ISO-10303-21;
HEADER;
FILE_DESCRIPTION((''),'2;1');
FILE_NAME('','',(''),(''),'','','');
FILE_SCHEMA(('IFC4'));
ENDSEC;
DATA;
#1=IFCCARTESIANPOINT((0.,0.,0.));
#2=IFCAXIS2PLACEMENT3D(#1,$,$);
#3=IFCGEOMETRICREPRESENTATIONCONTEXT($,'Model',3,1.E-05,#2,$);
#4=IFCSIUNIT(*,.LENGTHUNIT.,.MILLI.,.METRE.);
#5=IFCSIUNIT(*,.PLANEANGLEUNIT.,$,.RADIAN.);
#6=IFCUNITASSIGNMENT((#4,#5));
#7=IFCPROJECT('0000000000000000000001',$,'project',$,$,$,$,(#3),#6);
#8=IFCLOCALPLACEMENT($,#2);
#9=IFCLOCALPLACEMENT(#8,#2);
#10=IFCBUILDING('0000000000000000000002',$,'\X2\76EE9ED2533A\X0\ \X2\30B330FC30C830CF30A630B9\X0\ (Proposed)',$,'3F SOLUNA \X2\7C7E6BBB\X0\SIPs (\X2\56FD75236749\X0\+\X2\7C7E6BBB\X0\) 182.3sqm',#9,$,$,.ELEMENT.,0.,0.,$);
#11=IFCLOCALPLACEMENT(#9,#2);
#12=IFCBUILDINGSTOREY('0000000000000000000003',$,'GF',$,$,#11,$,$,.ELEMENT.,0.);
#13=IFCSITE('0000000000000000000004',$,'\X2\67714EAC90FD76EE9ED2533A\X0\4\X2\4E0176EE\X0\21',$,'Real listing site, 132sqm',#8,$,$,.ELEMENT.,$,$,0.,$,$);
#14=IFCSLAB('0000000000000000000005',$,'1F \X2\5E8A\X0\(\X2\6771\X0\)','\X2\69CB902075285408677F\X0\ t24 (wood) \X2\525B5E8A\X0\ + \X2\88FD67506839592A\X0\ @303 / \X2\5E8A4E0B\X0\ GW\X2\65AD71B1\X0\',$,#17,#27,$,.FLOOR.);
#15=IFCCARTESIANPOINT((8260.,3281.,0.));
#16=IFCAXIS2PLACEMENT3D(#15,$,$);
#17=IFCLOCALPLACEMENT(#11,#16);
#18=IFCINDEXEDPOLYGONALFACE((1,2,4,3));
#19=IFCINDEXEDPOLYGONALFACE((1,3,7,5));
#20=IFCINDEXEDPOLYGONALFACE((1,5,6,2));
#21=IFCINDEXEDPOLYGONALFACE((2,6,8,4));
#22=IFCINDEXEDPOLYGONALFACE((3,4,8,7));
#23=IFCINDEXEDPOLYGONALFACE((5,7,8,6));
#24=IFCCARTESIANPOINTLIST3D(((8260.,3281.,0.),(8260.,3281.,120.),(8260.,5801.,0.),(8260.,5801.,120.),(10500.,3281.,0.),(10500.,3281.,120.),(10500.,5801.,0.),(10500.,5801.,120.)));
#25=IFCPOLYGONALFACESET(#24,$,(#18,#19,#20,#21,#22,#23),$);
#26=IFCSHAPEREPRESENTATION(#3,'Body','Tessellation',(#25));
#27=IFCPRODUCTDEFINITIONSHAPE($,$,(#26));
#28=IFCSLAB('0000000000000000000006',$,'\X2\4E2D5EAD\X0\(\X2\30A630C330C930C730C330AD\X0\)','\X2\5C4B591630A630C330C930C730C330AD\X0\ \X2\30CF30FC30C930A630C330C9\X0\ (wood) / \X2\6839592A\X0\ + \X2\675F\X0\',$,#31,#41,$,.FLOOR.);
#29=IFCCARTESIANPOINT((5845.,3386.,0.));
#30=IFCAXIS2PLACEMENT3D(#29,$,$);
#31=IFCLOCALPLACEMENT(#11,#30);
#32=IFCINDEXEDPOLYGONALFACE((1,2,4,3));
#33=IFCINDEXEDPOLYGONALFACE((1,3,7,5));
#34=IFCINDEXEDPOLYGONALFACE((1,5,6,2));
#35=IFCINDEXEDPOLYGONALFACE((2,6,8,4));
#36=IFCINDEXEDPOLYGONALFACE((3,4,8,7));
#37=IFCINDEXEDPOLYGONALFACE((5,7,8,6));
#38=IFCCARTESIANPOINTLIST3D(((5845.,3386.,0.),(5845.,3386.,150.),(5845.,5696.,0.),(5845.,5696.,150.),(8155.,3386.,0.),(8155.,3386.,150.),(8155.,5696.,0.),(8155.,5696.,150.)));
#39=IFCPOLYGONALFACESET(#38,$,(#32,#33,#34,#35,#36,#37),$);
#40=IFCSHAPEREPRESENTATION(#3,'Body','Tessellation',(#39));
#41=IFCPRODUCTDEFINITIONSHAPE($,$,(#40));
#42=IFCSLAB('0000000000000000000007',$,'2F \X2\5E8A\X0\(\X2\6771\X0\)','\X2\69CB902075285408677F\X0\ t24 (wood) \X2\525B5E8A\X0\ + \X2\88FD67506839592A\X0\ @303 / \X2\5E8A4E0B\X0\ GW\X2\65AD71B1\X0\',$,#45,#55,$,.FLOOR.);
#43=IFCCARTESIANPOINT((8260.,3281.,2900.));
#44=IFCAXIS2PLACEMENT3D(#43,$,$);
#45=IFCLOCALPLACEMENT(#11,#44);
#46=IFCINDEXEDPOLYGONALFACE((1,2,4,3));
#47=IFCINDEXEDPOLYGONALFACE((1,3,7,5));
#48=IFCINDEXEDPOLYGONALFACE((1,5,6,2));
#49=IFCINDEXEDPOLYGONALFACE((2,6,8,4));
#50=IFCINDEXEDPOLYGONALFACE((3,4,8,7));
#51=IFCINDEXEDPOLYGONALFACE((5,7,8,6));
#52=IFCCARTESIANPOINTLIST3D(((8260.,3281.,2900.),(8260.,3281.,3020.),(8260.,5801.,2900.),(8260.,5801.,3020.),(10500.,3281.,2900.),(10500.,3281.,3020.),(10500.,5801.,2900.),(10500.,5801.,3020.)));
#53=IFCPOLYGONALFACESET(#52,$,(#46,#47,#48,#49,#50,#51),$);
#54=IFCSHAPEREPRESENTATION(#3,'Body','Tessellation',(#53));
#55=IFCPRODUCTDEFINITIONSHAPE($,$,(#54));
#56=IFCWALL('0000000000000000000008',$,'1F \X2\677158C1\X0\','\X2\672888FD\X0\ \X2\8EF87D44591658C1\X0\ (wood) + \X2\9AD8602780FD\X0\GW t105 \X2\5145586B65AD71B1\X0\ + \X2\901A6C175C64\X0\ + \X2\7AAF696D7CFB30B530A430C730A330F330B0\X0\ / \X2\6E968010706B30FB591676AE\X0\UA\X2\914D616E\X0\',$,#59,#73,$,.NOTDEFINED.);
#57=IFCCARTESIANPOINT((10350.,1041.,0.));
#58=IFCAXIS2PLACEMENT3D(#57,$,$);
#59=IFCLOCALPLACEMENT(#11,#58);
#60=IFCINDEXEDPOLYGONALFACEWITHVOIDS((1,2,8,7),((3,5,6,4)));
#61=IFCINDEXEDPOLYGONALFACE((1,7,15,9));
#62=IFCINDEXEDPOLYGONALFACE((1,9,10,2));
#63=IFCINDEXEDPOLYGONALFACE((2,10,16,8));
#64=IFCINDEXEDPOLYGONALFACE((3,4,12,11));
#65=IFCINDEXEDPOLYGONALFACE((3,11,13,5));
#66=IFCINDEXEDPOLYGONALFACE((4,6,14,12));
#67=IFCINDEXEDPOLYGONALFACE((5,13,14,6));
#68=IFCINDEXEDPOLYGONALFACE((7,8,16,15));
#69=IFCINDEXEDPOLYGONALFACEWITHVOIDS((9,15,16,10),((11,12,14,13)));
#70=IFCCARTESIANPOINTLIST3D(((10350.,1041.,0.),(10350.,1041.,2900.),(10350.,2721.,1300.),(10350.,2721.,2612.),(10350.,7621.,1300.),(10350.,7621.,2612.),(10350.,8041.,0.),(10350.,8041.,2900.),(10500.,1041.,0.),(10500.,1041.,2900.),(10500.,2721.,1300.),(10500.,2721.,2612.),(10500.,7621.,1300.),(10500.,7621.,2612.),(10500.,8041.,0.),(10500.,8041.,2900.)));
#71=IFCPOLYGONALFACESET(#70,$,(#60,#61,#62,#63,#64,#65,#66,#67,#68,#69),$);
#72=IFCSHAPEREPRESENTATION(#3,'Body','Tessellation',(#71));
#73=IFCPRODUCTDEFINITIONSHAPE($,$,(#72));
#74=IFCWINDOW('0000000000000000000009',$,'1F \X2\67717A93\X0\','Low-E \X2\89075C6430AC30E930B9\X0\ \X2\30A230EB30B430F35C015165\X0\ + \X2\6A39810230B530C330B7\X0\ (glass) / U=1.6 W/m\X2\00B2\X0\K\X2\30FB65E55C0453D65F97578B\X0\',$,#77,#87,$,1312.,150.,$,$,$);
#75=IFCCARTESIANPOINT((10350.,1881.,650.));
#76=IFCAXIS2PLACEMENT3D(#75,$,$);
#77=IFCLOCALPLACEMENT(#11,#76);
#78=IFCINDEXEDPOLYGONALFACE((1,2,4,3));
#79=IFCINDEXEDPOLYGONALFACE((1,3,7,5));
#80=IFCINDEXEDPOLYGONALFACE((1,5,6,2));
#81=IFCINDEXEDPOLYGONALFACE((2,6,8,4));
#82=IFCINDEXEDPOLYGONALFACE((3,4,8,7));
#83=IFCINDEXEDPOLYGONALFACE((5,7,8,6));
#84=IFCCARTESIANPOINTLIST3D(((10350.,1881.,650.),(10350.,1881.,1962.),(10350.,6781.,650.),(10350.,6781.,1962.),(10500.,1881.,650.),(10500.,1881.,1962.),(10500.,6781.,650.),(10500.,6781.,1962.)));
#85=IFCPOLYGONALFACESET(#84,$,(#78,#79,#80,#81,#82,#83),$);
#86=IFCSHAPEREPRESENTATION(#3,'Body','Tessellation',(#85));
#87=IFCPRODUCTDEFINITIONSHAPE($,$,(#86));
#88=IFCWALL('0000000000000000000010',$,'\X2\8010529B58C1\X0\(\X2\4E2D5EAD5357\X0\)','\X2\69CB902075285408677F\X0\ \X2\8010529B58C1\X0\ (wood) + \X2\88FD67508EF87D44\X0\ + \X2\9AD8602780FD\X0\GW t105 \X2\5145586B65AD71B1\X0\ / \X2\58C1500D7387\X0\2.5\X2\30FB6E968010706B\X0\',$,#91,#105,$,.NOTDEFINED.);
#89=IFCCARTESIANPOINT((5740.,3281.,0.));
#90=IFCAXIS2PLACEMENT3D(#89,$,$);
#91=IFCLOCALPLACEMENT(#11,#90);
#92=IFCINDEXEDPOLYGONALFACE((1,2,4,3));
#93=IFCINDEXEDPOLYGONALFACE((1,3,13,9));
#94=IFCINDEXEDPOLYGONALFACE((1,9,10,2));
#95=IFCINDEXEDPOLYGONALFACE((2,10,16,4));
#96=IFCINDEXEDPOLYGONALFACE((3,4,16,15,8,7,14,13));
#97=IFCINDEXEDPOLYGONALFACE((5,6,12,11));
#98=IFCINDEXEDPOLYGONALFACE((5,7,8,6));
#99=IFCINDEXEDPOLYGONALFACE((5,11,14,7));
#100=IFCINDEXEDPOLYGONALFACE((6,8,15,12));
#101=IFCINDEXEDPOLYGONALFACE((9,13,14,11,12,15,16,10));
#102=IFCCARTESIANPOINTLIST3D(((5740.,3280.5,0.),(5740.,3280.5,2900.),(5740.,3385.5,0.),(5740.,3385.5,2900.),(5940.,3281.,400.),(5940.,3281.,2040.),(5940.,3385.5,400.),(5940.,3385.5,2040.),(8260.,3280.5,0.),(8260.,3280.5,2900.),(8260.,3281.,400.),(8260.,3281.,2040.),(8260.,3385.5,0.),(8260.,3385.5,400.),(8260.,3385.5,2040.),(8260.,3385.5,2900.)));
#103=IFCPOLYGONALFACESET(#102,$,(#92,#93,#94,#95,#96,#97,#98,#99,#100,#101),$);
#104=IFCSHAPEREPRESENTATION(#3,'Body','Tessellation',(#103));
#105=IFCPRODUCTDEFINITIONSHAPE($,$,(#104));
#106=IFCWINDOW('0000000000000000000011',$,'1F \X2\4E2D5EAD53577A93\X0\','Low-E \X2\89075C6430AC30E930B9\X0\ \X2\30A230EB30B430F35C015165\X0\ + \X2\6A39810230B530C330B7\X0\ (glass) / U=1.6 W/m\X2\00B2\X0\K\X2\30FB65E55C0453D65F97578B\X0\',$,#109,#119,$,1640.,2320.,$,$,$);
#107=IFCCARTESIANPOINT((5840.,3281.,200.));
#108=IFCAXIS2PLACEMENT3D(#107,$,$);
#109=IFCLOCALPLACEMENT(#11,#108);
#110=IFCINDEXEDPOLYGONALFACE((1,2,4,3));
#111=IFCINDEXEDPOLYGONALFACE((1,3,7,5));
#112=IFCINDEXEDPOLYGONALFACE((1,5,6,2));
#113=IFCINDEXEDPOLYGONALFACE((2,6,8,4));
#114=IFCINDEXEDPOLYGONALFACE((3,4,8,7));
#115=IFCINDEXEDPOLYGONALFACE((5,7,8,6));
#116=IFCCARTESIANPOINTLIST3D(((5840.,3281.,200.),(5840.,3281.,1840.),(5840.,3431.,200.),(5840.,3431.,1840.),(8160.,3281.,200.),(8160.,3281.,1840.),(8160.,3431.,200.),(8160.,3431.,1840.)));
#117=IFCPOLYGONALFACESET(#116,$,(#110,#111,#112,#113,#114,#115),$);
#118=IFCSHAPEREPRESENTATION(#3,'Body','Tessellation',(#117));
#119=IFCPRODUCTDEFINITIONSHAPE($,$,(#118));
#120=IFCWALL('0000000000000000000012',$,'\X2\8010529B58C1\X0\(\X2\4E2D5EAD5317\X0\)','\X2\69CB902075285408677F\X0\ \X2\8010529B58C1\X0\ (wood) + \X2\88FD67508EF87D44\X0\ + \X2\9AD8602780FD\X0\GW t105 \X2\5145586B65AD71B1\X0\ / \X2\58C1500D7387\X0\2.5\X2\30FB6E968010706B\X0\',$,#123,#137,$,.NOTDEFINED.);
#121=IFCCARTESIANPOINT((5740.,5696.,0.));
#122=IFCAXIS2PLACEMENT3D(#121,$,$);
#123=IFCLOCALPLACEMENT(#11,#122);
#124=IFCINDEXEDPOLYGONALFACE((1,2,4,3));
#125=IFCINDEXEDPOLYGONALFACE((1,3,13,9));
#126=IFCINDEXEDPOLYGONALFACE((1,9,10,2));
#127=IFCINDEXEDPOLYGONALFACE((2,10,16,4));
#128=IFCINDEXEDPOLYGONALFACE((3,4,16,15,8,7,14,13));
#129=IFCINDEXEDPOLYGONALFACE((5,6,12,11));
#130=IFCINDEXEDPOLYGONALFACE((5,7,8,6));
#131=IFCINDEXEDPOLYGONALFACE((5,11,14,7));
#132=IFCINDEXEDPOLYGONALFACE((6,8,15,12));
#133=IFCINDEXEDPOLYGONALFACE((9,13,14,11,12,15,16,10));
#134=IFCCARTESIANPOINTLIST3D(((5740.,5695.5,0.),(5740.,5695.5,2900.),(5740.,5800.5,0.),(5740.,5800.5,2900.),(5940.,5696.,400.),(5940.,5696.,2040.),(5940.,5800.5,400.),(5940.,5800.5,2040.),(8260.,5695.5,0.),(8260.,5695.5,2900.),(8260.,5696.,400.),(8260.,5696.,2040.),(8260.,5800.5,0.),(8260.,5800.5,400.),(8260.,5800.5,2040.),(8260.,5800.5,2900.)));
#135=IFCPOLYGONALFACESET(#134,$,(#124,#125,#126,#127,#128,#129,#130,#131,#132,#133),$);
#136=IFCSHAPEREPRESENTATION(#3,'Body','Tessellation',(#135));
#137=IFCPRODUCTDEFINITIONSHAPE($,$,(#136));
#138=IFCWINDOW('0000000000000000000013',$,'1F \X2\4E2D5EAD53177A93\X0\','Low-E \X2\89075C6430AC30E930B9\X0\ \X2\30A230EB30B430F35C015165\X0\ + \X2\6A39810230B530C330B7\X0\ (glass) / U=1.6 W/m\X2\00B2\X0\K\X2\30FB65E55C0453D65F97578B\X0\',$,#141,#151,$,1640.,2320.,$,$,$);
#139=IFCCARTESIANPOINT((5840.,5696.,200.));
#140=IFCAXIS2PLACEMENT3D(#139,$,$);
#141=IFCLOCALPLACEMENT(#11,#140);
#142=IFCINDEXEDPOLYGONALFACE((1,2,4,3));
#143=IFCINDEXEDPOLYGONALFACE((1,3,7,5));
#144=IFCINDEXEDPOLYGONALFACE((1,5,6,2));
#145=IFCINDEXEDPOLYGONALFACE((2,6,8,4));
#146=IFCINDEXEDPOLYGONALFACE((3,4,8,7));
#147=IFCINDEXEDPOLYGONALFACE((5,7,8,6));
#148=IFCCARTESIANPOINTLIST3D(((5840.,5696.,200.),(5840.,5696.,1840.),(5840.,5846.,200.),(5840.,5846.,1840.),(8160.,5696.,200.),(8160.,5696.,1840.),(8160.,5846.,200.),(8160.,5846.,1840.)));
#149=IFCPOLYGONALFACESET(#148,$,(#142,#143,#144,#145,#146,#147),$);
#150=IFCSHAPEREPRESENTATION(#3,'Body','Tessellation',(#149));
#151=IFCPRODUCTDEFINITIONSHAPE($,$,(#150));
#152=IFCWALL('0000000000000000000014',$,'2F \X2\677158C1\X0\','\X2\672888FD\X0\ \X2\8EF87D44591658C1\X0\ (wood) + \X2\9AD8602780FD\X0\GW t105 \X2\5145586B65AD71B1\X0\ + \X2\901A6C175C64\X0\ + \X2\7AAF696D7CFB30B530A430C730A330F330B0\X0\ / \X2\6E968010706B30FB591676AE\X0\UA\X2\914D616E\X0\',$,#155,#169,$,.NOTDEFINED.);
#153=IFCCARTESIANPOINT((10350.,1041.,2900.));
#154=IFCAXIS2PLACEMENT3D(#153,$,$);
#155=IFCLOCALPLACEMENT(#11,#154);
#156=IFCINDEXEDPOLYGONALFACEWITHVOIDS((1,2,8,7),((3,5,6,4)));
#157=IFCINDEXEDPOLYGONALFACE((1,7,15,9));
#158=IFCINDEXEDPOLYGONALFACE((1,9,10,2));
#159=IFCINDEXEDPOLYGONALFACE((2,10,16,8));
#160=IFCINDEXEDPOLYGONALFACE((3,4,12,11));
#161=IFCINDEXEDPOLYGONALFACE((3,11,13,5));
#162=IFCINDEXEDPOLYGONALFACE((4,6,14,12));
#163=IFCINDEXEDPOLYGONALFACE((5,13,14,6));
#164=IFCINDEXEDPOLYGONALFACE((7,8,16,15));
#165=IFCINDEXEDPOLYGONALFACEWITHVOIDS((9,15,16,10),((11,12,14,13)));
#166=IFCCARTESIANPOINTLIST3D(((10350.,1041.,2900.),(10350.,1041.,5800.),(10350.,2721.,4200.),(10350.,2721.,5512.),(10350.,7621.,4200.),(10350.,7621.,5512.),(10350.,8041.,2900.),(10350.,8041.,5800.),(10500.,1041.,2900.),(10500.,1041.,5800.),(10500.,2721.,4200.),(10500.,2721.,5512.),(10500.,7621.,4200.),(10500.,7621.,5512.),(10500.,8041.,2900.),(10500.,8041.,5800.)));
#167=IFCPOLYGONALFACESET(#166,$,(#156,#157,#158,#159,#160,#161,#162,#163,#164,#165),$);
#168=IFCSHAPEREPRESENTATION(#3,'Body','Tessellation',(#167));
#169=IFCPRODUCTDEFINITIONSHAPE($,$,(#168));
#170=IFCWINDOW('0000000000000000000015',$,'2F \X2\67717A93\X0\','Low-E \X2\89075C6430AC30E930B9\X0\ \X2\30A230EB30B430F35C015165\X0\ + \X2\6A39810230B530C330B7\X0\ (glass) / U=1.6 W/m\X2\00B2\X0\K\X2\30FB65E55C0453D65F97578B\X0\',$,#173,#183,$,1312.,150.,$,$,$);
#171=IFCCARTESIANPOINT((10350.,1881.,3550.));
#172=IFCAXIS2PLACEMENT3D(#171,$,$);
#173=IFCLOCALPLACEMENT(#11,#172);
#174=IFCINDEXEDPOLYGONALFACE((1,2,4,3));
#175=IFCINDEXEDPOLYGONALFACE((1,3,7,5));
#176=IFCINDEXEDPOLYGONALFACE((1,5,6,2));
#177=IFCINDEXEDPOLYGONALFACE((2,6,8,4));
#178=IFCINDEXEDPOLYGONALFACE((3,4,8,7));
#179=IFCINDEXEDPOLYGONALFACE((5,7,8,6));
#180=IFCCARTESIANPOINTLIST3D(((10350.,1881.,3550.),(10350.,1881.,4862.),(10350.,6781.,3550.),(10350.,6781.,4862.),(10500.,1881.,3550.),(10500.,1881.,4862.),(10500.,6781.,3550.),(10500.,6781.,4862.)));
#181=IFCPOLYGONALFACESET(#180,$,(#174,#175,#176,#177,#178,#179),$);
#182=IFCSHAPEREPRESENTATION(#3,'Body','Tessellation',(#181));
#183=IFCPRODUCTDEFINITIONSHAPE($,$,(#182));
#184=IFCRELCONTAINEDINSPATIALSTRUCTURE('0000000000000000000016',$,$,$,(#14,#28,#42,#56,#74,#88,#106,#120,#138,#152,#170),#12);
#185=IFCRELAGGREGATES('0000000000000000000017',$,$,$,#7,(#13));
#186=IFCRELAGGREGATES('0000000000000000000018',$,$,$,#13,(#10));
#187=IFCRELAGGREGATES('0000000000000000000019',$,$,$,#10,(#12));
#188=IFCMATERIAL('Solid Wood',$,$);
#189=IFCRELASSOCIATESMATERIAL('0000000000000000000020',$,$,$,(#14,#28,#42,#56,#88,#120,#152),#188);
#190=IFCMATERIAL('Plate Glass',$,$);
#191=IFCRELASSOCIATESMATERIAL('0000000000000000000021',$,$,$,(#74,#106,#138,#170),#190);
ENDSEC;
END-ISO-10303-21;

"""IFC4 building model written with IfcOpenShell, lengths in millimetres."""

from ifc_helpers import new_model, si_unit, frame, frame_2d, origin, place, context, project, spatial, rectangle, extrude, material, element, fill, save


model = new_model("IFC4")

# Units and contexts
model_context = context("Model", 3, precision=1e-05, world=origin())
ifc_project = project(units=[si_unit("LENGTHUNIT", "METRE", prefix="MILLI"), si_unit("PLANEANGLEUNIT", "RADIAN")], contexts=[model_context])

# Site, building, storey
site_placement = place(None, origin())
site = spatial("IfcSite", under=ifc_project, at=site_placement, Name="東京都目黒区4丁目21", ObjectType="Real listing site, 132sqm", CompositionType="ELEMENT", RefElevation=0.0)
building_placement = place(site_placement, origin())
building = spatial("IfcBuilding", under=site, at=building_placement, Name="目黒区 コートハウス (Proposed)", ObjectType="3F SOLUNA 籾殻SIPs (国産杉+籾殻) 182.3sqm", CompositionType="ELEMENT", ElevationOfRefHeight=0.0, ElevationOfTerrain=0.0)
storey_placement = place(building_placement, origin())
storey = spatial("IfcBuildingStorey", under=building, at=storey_placement, Name="GF", CompositionType="ELEMENT", Elevation=0.0)

# Slabs
ifc_material_1 = material(Name="Solid Wood")
slab_1_placement = place(storey_placement, frame((8260.0, 3281.0, 0.0)))
element("IfcSlab", 1, at=slab_1_placement, inside=storey, material=ifc_material_1, Name="1F 床(東)", Description="構造用合板 t24 (wood) 剛床 + 製材根太 @303 / 床下 GW断熱", PredefinedType="FLOOR", context=model_context, shape_type="SweptSolid", body=[
    extrude(rectangle(XDim=2240.0, YDim=2520.0, at=frame_2d((1120.0, 1260.0))), frame((8260.0, 3281.0, 0.0)), (0.0, 0.0, 1.0), 120.0),
])
slab_2_placement = place(storey_placement, frame((5845.0, 3386.0, 0.0)))
element("IfcSlab", 2, at=slab_2_placement, inside=storey, material=ifc_material_1, Name="中庭(ウッドデッキ)", Description="屋外ウッドデッキ ハードウッド (wood) / 根太 + 束", PredefinedType="FLOOR", context=model_context, shape_type="SweptSolid", body=[
    extrude(rectangle(XDim=2310.0, YDim=2310.0, at=frame_2d((1155.0, 1155.0))), frame((5845.0, 3386.0, 0.0)), (0.0, 0.0, 1.0), 150.0),
])
slab_3_placement = place(storey_placement, frame((8260.0, 3281.0, 2900.0)))
element("IfcSlab", 3, at=slab_3_placement, inside=storey, material=ifc_material_1, Name="2F 床(東)", Description="構造用合板 t24 (wood) 剛床 + 製材根太 @303 / 床下 GW断熱", PredefinedType="FLOOR", context=model_context, shape_type="SweptSolid", body=[
    extrude(rectangle(XDim=2240.0, YDim=2520.0, at=frame_2d((1120.0, 1260.0))), frame((8260.0, 3281.0, 2900.0)), (0.0, 0.0, 1.0), 120.0),
])

# Walls, openings, windows
wall_1_placement = place(storey_placement, frame((10350.0, 1041.0, 0.0)))
wall_1 = element("IfcWall", 4, at=wall_1_placement, inside=storey, material=ifc_material_1, Name="1F 東壁", Description="木製 軸組外壁 (wood) + 高性能GW t105 充填断熱 + 通気層 + 窯業系サイディング / 準耐火・外皮UA配慮", PredefinedType="NOTDEFINED", context=model_context, shape_type="SweptSolid", body=[
    extrude(rectangle(XDim=150.0, YDim=7000.0, at=frame_2d((75.0, 3500.0))), frame((10350.0, 1041.0, 0.0)), (0.0, 0.0, 1.0), 2900.0),
])
opening_1_placement = place(storey_placement, frame((10350.0, 1881.0, 650.0)))
opening_1 = element("IfcOpeningElement", 5, at=opening_1_placement, cuts=wall_1, PredefinedType="NOTDEFINED", context=model_context, shape_type="SweptSolid", body=[
    extrude(rectangle(XDim=150.0, YDim=4900.0, at=frame_2d((75.0, 2450.0))), frame((10350.0, 1881.0, 650.0)), (0.0, 0.0, 1.0), 1312.0),
])
ifc_material_2 = material(Name="Plate Glass")
window_1_placement = place(storey_placement, frame((10350.0, 1881.0, 650.0)))
window_1 = element("IfcWindow", 6, at=window_1_placement, inside=storey, material=ifc_material_2, Name="1F 東窓", Description="Low-E 複層ガラス アルゴン封入 + 樹脂サッシ (glass) / U=1.6 W/m²K・日射取得型", OverallHeight=1312.0, OverallWidth=150.0, context=model_context, shape_type="SweptSolid", body=[
    extrude(rectangle(XDim=150.0, YDim=4900.0, at=frame_2d((75.0, 2450.0))), frame((10350.0, 1881.0, 650.0)), (0.0, 0.0, 1.0), 1312.0),
])
fill(opening_1, window_1)
wall_2_placement = place(storey_placement, frame((5740.0, 3281.0, 0.0)))
wall_2 = element("IfcWall", 7, at=wall_2_placement, inside=storey, material=ifc_material_1, Name="耐力壁(中庭南)", Description="構造用合板 耐力壁 (wood) + 製材軸組 + 高性能GW t105 充填断熱 / 壁倍率2.5・準耐火", PredefinedType="NOTDEFINED", context=model_context, shape_type="SweptSolid", body=[
    extrude(rectangle(XDim=2520.0, YDim=105.0, at=frame_2d((1260.0, 52.0))), frame((5740.0, 3281.0, 0.0)), (0.0, 0.0, 1.0), 2900.0),
])
opening_2_placement = place(storey_placement, frame((5840.0, 3281.0, 200.0)))
opening_2 = element("IfcOpeningElement", 8, at=opening_2_placement, cuts=wall_2, PredefinedType="NOTDEFINED", context=model_context, shape_type="SweptSolid", body=[
    extrude(rectangle(XDim=2320.0, YDim=150.0, at=frame_2d((1160.0, 75.0))), frame((5840.0, 3281.0, 200.0)), (0.0, 0.0, 1.0), 1640.0),
])
window_2_placement = place(storey_placement, frame((5840.0, 3281.0, 200.0)))
window_2 = element("IfcWindow", 9, at=window_2_placement, inside=storey, material=ifc_material_2, Name="1F 中庭南窓", Description="Low-E 複層ガラス アルゴン封入 + 樹脂サッシ (glass) / U=1.6 W/m²K・日射取得型", OverallHeight=1640.0, OverallWidth=2320.0, context=model_context, shape_type="SweptSolid", body=[
    extrude(rectangle(XDim=2320.0, YDim=150.0, at=frame_2d((1160.0, 75.0))), frame((5840.0, 3281.0, 200.0)), (0.0, 0.0, 1.0), 1640.0),
])
fill(opening_2, window_2)
wall_3_placement = place(storey_placement, frame((5740.0, 5696.0, 0.0)))
wall_3 = element("IfcWall", 10, at=wall_3_placement, inside=storey, material=ifc_material_1, Name="耐力壁(中庭北)", Description="構造用合板 耐力壁 (wood) + 製材軸組 + 高性能GW t105 充填断熱 / 壁倍率2.5・準耐火", PredefinedType="NOTDEFINED", context=model_context, shape_type="SweptSolid", body=[
    extrude(rectangle(XDim=2520.0, YDim=105.0, at=frame_2d((1260.0, 52.0))), frame((5740.0, 5696.0, 0.0)), (0.0, 0.0, 1.0), 2900.0),
])
opening_3_placement = place(storey_placement, frame((5840.0, 5696.0, 200.0)))
opening_3 = element("IfcOpeningElement", 11, at=opening_3_placement, cuts=wall_3, PredefinedType="NOTDEFINED", context=model_context, shape_type="SweptSolid", body=[
    extrude(rectangle(XDim=2320.0, YDim=150.0, at=frame_2d((1160.0, 75.0))), frame((5840.0, 5696.0, 200.0)), (0.0, 0.0, 1.0), 1640.0),
])
window_3_placement = place(storey_placement, frame((5840.0, 5696.0, 200.0)))
window_3 = element("IfcWindow", 12, at=window_3_placement, inside=storey, material=ifc_material_2, Name="1F 中庭北窓", Description="Low-E 複層ガラス アルゴン封入 + 樹脂サッシ (glass) / U=1.6 W/m²K・日射取得型", OverallHeight=1640.0, OverallWidth=2320.0, context=model_context, shape_type="SweptSolid", body=[
    extrude(rectangle(XDim=2320.0, YDim=150.0, at=frame_2d((1160.0, 75.0))), frame((5840.0, 5696.0, 200.0)), (0.0, 0.0, 1.0), 1640.0),
])
fill(opening_3, window_3)

# Wall, opening, window
wall_4_placement = place(storey_placement, frame((10350.0, 1041.0, 2900.0)))
wall_4 = element("IfcWall", 13, at=wall_4_placement, inside=storey, material=ifc_material_1, Name="2F 東壁", Description="木製 軸組外壁 (wood) + 高性能GW t105 充填断熱 + 通気層 + 窯業系サイディング / 準耐火・外皮UA配慮", PredefinedType="NOTDEFINED", context=model_context, shape_type="SweptSolid", body=[
    extrude(rectangle(XDim=150.0, YDim=7000.0, at=frame_2d((75.0, 3500.0))), frame((10350.0, 1041.0, 2900.0)), (0.0, 0.0, 1.0), 2900.0),
])
opening_4_placement = place(storey_placement, frame((10350.0, 1881.0, 3550.0)))
opening_4 = element("IfcOpeningElement", 14, at=opening_4_placement, cuts=wall_4, PredefinedType="NOTDEFINED", context=model_context, shape_type="SweptSolid", body=[
    extrude(rectangle(XDim=150.0, YDim=4900.0, at=frame_2d((75.0, 2450.0))), frame((10350.0, 1881.0, 3550.0)), (0.0, 0.0, 1.0), 1312.0),
])
window_4_placement = place(storey_placement, frame((10350.0, 1881.0, 3550.0)))
window_4 = element("IfcWindow", 15, at=window_4_placement, inside=storey, material=ifc_material_2, Name="2F 東窓", Description="Low-E 複層ガラス アルゴン封入 + 樹脂サッシ (glass) / U=1.6 W/m²K・日射取得型", OverallHeight=1312.0, OverallWidth=150.0, context=model_context, shape_type="SweptSolid", body=[
    extrude(rectangle(XDim=150.0, YDim=4900.0, at=frame_2d((75.0, 2450.0))), frame((10350.0, 1881.0, 3550.0)), (0.0, 0.0, 1.0), 1312.0),
])
fill(opening_4, window_4)

save(model, "model.ifc")
